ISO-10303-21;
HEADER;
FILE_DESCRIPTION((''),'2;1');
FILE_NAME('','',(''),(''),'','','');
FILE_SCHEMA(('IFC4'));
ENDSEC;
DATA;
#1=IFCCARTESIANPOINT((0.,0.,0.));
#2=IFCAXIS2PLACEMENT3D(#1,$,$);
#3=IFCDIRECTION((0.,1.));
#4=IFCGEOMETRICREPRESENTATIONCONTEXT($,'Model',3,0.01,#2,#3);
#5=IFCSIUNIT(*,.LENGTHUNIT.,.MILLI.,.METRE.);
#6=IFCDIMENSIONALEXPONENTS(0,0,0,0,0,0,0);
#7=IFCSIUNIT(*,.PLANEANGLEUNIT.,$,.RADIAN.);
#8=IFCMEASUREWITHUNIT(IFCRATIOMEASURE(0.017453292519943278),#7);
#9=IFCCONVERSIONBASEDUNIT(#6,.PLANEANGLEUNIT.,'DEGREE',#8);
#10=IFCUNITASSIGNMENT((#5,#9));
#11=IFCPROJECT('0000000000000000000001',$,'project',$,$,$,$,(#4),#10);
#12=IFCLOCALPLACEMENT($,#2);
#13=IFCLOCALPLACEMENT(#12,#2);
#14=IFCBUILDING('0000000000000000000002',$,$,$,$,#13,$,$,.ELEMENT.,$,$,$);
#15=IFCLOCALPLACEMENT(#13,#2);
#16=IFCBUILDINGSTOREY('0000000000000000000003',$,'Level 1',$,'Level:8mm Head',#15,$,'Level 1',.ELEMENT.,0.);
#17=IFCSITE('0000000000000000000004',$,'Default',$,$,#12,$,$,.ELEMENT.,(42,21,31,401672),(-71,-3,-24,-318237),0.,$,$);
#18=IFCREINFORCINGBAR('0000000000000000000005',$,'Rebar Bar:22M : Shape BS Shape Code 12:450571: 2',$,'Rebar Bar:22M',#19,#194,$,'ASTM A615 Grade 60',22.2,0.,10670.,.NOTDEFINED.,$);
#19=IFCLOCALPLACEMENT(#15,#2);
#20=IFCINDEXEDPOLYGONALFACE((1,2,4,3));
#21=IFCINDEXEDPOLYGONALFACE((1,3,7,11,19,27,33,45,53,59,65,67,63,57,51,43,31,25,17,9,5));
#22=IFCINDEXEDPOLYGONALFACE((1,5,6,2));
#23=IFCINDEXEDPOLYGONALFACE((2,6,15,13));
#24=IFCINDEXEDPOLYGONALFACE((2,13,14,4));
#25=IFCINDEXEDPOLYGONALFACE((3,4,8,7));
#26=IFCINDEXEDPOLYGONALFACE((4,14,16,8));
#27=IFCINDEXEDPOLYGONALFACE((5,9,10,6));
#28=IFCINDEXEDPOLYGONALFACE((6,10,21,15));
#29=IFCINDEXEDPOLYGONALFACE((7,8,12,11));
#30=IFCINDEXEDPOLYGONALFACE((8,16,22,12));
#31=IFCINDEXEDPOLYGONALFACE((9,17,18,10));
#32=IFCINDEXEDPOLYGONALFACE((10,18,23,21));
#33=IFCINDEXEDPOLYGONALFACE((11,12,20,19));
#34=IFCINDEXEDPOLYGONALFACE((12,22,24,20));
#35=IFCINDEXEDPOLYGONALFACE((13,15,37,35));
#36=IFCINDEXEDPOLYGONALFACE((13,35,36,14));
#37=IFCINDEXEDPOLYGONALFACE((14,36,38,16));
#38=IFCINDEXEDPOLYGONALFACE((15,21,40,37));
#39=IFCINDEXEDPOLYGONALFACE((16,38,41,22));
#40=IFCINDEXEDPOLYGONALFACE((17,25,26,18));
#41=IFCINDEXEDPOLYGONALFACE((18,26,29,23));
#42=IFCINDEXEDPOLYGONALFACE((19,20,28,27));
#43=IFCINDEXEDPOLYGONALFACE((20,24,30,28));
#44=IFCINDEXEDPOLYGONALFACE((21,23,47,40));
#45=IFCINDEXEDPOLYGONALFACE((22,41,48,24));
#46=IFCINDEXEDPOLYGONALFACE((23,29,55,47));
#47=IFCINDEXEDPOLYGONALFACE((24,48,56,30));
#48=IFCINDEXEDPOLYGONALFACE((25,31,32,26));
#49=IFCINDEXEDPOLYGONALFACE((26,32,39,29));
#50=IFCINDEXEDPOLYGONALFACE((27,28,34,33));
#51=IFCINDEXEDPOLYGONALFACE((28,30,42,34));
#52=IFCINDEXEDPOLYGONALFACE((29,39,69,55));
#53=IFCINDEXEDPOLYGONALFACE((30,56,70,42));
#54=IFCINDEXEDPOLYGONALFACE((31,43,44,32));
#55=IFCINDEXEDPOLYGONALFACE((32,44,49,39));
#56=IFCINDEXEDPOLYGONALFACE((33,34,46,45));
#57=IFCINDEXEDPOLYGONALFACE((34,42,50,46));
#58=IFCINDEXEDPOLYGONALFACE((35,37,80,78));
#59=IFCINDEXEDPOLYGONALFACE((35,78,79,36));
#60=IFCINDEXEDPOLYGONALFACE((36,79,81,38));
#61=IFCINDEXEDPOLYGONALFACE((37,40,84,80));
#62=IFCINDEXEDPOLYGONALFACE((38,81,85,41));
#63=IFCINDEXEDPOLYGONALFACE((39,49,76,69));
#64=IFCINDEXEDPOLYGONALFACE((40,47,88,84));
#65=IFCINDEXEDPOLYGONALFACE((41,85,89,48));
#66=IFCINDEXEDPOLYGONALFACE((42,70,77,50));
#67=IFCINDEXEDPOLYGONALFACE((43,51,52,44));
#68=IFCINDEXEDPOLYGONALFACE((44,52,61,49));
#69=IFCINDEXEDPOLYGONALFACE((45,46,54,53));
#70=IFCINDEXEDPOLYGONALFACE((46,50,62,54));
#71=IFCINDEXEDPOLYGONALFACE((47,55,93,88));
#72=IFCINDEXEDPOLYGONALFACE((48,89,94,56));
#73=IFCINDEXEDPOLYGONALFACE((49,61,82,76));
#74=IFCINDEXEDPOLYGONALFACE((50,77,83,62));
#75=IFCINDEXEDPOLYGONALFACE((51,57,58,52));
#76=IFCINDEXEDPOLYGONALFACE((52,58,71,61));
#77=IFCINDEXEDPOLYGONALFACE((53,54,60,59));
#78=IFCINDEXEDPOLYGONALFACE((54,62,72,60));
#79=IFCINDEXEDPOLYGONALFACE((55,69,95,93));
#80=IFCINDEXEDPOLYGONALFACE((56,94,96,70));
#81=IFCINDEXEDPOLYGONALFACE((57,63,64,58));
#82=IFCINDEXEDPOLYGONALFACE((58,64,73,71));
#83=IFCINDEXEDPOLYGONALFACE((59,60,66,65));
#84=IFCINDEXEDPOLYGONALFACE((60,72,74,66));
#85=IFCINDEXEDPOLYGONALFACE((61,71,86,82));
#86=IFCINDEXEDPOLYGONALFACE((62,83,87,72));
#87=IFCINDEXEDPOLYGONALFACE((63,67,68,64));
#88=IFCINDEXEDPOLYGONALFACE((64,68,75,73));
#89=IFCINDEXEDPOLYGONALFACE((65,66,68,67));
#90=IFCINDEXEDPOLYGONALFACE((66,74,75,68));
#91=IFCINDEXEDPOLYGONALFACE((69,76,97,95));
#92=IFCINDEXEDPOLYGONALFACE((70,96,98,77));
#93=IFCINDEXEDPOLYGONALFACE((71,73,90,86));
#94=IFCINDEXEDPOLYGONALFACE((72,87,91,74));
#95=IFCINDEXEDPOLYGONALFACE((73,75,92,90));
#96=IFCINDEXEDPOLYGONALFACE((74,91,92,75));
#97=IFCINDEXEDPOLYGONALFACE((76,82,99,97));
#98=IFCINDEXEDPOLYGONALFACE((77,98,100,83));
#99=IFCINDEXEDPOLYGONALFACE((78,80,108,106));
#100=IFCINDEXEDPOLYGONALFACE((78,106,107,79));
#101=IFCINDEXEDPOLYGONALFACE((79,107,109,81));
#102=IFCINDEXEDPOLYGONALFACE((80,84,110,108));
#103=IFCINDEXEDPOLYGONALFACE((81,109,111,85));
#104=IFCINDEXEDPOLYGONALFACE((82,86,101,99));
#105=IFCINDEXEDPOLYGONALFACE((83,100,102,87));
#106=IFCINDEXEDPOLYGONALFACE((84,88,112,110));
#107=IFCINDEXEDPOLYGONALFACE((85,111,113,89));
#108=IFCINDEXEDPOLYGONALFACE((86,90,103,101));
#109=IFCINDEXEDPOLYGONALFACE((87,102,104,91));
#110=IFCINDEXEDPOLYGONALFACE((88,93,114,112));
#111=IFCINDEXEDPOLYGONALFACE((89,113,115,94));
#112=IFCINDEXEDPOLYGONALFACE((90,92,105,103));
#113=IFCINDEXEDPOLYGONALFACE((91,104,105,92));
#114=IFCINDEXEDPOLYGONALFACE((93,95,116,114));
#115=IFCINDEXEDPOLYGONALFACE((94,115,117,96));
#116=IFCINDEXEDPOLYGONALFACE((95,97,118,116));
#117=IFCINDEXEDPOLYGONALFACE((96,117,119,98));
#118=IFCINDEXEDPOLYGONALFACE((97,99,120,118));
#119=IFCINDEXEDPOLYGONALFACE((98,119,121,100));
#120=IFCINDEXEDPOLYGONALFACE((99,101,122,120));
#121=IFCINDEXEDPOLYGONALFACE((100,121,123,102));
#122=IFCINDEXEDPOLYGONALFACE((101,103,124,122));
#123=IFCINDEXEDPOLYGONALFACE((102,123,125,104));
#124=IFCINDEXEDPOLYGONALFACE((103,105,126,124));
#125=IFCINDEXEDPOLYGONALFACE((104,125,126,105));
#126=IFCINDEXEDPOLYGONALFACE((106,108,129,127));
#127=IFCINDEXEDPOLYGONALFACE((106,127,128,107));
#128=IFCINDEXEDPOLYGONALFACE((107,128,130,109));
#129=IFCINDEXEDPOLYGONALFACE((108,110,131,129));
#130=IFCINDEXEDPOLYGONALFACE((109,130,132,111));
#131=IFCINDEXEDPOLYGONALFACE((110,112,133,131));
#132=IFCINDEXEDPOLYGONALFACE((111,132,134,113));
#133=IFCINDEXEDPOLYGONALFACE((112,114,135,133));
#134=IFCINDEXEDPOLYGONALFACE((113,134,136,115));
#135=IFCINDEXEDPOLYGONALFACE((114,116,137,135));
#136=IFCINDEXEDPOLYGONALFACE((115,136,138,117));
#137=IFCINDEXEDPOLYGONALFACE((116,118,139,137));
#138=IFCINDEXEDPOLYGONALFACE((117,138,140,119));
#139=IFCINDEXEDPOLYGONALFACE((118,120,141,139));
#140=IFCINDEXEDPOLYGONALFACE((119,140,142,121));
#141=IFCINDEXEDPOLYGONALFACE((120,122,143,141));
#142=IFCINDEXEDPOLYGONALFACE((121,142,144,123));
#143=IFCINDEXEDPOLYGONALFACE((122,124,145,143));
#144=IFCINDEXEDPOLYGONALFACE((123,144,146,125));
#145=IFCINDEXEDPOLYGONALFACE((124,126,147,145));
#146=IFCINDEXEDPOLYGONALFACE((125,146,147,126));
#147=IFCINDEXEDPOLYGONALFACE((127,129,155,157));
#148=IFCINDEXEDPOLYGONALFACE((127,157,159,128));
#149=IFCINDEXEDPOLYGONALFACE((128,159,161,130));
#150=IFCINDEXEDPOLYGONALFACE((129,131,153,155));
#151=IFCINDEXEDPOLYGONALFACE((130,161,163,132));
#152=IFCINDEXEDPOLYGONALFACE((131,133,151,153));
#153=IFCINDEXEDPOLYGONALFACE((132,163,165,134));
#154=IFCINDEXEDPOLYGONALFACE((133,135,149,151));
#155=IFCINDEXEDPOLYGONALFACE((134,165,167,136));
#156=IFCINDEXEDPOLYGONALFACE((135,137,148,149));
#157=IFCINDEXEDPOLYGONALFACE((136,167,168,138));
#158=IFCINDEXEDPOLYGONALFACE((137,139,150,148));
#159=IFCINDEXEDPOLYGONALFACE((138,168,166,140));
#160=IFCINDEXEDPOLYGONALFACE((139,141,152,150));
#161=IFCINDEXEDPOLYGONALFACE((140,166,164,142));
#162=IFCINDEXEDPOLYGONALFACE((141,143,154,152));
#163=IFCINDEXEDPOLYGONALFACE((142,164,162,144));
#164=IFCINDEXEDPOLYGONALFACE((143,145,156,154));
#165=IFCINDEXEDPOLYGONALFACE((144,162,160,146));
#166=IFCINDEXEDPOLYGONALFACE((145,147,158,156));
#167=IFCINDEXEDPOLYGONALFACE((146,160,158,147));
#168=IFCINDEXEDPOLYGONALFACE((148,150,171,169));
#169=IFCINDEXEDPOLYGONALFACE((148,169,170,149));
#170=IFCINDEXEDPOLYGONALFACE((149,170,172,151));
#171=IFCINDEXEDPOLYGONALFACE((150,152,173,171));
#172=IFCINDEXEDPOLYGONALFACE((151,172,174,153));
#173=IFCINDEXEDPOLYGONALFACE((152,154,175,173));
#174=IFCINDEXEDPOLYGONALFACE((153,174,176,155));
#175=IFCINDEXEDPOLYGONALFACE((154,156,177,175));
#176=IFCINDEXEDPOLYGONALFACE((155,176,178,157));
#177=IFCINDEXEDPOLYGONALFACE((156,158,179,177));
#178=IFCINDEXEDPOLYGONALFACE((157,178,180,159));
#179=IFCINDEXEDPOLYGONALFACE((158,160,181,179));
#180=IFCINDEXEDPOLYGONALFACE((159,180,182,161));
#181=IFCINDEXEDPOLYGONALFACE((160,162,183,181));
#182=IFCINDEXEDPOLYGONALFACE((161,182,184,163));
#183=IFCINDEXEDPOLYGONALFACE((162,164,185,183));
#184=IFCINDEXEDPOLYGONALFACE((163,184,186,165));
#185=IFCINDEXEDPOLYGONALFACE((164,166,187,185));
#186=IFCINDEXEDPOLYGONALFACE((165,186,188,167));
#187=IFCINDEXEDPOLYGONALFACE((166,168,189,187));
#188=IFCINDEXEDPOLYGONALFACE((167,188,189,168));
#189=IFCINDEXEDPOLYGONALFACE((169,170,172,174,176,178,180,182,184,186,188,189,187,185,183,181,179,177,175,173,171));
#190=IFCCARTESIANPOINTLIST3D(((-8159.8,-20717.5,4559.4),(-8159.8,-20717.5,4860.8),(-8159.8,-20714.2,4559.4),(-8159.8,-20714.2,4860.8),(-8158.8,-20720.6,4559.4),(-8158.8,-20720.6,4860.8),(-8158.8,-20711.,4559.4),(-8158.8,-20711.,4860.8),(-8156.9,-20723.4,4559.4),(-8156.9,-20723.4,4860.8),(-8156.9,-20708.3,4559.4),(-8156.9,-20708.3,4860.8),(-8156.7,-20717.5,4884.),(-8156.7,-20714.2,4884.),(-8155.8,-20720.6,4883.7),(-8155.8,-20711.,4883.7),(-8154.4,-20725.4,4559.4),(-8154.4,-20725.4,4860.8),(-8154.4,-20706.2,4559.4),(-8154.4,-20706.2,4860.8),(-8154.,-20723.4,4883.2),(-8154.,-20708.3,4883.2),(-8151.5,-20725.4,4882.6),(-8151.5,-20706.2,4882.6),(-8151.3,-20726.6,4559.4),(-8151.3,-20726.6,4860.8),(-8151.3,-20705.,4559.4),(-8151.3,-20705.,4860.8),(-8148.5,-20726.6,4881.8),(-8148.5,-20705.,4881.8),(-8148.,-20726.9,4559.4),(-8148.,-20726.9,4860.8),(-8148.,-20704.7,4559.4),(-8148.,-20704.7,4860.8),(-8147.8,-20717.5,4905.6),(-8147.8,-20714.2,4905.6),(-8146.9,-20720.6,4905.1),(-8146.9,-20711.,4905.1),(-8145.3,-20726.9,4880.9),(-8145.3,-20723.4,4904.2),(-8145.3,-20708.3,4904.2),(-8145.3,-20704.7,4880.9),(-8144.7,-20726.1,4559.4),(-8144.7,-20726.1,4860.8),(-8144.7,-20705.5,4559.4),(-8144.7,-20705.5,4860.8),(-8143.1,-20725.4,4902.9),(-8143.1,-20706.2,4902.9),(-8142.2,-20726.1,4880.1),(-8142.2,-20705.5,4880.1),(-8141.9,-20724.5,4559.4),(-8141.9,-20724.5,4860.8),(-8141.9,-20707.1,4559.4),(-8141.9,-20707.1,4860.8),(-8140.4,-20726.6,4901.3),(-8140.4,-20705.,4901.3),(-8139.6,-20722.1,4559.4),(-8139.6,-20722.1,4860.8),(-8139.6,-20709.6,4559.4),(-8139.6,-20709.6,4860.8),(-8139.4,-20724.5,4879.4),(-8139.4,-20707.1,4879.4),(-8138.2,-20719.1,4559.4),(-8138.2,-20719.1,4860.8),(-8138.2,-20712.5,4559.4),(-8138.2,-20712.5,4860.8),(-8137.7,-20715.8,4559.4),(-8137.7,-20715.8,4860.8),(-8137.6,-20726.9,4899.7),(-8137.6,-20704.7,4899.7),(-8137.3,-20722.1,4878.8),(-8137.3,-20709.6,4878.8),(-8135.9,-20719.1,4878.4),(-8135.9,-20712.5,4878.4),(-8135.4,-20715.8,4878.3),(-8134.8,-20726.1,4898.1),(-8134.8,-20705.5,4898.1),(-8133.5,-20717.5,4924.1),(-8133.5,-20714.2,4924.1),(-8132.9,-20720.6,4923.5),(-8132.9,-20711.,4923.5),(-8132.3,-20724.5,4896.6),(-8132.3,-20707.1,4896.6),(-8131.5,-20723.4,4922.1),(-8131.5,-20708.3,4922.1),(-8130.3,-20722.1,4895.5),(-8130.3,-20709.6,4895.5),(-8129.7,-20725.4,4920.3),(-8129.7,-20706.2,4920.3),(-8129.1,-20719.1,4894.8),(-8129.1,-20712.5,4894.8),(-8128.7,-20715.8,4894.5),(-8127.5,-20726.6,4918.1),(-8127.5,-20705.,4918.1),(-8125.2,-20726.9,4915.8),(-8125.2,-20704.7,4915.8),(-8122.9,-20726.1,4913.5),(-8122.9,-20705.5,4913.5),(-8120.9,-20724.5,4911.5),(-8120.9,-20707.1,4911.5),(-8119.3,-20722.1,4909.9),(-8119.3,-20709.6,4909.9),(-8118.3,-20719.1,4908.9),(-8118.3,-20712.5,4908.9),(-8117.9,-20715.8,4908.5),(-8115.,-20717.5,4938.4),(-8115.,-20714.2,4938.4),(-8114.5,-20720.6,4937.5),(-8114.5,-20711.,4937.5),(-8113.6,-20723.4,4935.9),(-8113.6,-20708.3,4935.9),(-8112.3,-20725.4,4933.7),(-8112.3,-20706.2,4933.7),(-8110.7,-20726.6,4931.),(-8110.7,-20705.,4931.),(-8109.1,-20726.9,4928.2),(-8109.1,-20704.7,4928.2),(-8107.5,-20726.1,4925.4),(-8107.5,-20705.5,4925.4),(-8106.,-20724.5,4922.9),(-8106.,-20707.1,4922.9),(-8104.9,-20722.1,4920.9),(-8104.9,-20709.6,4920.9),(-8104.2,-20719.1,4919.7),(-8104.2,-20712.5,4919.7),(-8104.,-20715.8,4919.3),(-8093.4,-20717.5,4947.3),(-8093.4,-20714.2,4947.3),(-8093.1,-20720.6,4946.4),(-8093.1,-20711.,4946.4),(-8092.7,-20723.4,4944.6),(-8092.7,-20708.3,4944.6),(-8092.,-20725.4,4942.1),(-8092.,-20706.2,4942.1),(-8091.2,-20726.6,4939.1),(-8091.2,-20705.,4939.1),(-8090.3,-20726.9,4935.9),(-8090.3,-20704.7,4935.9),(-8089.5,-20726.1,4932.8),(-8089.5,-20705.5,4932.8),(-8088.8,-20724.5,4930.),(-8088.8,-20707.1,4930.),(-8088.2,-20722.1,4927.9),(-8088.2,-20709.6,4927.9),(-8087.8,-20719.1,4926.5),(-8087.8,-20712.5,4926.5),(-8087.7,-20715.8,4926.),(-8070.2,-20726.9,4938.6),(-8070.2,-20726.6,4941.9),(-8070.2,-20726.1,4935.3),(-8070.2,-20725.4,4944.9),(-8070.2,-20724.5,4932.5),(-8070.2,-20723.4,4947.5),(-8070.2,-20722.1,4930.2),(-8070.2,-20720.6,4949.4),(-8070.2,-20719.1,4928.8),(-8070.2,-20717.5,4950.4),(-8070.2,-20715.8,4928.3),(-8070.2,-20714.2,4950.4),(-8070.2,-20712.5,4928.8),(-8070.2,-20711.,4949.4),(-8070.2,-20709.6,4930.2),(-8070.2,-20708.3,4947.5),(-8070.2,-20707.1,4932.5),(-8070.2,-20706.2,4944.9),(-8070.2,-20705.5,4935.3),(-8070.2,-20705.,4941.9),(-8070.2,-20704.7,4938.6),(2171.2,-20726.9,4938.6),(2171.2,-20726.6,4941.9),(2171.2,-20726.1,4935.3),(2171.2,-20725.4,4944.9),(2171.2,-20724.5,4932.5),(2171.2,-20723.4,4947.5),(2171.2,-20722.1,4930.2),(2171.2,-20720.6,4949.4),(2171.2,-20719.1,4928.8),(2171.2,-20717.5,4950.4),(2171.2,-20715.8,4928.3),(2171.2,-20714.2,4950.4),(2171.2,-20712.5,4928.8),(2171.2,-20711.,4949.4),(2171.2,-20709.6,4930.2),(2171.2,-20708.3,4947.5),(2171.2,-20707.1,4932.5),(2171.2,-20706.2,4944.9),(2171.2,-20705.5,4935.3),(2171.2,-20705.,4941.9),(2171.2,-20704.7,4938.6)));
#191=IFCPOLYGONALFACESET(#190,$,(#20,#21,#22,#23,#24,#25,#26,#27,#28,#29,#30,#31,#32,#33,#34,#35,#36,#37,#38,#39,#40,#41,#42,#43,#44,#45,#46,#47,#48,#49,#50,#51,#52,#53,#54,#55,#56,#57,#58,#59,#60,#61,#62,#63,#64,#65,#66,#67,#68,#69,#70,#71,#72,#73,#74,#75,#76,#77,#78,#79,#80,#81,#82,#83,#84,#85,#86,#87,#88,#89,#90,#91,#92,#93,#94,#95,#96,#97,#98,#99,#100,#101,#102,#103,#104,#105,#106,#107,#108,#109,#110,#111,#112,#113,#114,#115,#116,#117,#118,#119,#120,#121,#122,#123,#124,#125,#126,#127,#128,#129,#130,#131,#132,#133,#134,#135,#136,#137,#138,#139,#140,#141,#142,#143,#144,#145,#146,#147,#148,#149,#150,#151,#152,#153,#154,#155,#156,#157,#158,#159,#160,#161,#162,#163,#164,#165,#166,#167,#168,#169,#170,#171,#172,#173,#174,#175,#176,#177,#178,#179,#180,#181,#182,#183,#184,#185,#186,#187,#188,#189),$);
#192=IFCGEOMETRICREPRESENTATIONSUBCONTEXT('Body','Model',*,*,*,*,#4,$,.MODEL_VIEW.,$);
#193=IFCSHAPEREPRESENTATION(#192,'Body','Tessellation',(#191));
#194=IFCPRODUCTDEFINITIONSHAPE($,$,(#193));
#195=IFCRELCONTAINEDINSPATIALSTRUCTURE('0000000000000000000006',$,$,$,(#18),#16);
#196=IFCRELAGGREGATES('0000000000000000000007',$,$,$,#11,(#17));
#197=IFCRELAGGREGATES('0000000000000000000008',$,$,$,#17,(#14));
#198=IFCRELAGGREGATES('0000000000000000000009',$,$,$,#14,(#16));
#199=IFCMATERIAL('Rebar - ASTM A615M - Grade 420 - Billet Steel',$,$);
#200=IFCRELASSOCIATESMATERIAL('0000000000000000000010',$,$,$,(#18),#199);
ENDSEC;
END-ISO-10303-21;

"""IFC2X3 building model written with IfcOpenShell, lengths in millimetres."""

from ifc_helpers import new_model, entity, si_unit, converted_unit, direction, origin, place, context, subcontext, project, spatial, material, element, save


model = new_model("IFC2X3")

# Units and contexts
model_context = context("Model", 3, precision=0.01, world=origin(), true_north=direction((0.0, 1.0)))
body_context = subcontext(model_context, "Body", "Model", "MODEL_VIEW")
ifc_project = project(units=[si_unit("LENGTHUNIT", "METRE", prefix="MILLI"), converted_unit("PLANEANGLEUNIT", "DEGREE", entity("IfcRatioMeasure", 0.017453292519943278), si_unit("PLANEANGLEUNIT", "RADIAN"), dimensions=[0, 0, 0, 0, 0, 0, 0])], contexts=[model_context])

# Site, building, storey
site_placement = place(None, origin())
site = spatial("IfcSite", under=ifc_project, at=site_placement, Name="Default", CompositionType="ELEMENT", RefLatitude=(42, 21, 31, 401672), RefLongitude=(-71, -3, -24, -318237), RefElevation=0.0)
building_placement = place(site_placement, origin())
building = spatial("IfcBuilding", under=site, at=building_placement, CompositionType="ELEMENT")
storey_placement = place(building_placement, origin())
storey = spatial("IfcBuildingStorey", under=building, at=storey_placement, Name="Level 1", ObjectType="Level:8mm Head", LongName="Level 1", CompositionType="ELEMENT", Elevation=0.0)

# Reinforcing bar
ifc_material = material(Name="Rebar - ASTM A615M - Grade 420 - Billet Steel")
reinforcing_bar_1_placement = place(storey_placement, origin())
element("IfcReinforcingBar", 1, at=reinforcing_bar_1_placement, inside=storey, material=ifc_material, Name="Rebar Bar:22M : Shape BS Shape Code 12:450571: 2", SteelGrade="ASTM A615 Grade 60", ObjectType="Rebar Bar:22M", BarLength=10670.0, BarRole="NOTDEFINED", CrossSectionArea=0.0, NominalDiameter=22.2, context=body_context, shape_type="AdvancedSweptSolid", body=[
    entity("IfcSweptDiskSolid", entity("IfcCompositeCurve", [entity("IfcCompositeCurveSegment", "CONTINUOUS", True, entity("IfcPolyline", [entity("IfcCartesianPoint", [2171.2, -20715.8, 4939.4]), entity("IfcCartesianPoint", [-8070.2, -20715.8, 4939.4])])), entity("IfcCompositeCurveSegment", "CONTINUOUS", True, entity("IfcTrimmedCurve", entity("IfcCircle", entity("IfcAxis2Placement3D", entity("IfcCartesianPoint", [-8070.2, -20715.8, 4860.8]), entity("IfcDirection", [0.0, -1.0, 0.0]), entity("IfcDirection", [-1.0, 0.0, 0.0])), 78.6), [entity("IfcParameterValue", 270.0)], [entity("IfcParameterValue", 360.0)], True, "PARAMETER")), entity("IfcCompositeCurveSegment", "CONTINUOUS", True, entity("IfcPolyline", [entity("IfcCartesianPoint", [-8148.8, -20715.8, 4860.8]), entity("IfcCartesianPoint", [-8148.8, -20715.8, 4559.4])]))], False), 11.1, None, 0.0, 92.0),
])

save(model, "model.ifc")
